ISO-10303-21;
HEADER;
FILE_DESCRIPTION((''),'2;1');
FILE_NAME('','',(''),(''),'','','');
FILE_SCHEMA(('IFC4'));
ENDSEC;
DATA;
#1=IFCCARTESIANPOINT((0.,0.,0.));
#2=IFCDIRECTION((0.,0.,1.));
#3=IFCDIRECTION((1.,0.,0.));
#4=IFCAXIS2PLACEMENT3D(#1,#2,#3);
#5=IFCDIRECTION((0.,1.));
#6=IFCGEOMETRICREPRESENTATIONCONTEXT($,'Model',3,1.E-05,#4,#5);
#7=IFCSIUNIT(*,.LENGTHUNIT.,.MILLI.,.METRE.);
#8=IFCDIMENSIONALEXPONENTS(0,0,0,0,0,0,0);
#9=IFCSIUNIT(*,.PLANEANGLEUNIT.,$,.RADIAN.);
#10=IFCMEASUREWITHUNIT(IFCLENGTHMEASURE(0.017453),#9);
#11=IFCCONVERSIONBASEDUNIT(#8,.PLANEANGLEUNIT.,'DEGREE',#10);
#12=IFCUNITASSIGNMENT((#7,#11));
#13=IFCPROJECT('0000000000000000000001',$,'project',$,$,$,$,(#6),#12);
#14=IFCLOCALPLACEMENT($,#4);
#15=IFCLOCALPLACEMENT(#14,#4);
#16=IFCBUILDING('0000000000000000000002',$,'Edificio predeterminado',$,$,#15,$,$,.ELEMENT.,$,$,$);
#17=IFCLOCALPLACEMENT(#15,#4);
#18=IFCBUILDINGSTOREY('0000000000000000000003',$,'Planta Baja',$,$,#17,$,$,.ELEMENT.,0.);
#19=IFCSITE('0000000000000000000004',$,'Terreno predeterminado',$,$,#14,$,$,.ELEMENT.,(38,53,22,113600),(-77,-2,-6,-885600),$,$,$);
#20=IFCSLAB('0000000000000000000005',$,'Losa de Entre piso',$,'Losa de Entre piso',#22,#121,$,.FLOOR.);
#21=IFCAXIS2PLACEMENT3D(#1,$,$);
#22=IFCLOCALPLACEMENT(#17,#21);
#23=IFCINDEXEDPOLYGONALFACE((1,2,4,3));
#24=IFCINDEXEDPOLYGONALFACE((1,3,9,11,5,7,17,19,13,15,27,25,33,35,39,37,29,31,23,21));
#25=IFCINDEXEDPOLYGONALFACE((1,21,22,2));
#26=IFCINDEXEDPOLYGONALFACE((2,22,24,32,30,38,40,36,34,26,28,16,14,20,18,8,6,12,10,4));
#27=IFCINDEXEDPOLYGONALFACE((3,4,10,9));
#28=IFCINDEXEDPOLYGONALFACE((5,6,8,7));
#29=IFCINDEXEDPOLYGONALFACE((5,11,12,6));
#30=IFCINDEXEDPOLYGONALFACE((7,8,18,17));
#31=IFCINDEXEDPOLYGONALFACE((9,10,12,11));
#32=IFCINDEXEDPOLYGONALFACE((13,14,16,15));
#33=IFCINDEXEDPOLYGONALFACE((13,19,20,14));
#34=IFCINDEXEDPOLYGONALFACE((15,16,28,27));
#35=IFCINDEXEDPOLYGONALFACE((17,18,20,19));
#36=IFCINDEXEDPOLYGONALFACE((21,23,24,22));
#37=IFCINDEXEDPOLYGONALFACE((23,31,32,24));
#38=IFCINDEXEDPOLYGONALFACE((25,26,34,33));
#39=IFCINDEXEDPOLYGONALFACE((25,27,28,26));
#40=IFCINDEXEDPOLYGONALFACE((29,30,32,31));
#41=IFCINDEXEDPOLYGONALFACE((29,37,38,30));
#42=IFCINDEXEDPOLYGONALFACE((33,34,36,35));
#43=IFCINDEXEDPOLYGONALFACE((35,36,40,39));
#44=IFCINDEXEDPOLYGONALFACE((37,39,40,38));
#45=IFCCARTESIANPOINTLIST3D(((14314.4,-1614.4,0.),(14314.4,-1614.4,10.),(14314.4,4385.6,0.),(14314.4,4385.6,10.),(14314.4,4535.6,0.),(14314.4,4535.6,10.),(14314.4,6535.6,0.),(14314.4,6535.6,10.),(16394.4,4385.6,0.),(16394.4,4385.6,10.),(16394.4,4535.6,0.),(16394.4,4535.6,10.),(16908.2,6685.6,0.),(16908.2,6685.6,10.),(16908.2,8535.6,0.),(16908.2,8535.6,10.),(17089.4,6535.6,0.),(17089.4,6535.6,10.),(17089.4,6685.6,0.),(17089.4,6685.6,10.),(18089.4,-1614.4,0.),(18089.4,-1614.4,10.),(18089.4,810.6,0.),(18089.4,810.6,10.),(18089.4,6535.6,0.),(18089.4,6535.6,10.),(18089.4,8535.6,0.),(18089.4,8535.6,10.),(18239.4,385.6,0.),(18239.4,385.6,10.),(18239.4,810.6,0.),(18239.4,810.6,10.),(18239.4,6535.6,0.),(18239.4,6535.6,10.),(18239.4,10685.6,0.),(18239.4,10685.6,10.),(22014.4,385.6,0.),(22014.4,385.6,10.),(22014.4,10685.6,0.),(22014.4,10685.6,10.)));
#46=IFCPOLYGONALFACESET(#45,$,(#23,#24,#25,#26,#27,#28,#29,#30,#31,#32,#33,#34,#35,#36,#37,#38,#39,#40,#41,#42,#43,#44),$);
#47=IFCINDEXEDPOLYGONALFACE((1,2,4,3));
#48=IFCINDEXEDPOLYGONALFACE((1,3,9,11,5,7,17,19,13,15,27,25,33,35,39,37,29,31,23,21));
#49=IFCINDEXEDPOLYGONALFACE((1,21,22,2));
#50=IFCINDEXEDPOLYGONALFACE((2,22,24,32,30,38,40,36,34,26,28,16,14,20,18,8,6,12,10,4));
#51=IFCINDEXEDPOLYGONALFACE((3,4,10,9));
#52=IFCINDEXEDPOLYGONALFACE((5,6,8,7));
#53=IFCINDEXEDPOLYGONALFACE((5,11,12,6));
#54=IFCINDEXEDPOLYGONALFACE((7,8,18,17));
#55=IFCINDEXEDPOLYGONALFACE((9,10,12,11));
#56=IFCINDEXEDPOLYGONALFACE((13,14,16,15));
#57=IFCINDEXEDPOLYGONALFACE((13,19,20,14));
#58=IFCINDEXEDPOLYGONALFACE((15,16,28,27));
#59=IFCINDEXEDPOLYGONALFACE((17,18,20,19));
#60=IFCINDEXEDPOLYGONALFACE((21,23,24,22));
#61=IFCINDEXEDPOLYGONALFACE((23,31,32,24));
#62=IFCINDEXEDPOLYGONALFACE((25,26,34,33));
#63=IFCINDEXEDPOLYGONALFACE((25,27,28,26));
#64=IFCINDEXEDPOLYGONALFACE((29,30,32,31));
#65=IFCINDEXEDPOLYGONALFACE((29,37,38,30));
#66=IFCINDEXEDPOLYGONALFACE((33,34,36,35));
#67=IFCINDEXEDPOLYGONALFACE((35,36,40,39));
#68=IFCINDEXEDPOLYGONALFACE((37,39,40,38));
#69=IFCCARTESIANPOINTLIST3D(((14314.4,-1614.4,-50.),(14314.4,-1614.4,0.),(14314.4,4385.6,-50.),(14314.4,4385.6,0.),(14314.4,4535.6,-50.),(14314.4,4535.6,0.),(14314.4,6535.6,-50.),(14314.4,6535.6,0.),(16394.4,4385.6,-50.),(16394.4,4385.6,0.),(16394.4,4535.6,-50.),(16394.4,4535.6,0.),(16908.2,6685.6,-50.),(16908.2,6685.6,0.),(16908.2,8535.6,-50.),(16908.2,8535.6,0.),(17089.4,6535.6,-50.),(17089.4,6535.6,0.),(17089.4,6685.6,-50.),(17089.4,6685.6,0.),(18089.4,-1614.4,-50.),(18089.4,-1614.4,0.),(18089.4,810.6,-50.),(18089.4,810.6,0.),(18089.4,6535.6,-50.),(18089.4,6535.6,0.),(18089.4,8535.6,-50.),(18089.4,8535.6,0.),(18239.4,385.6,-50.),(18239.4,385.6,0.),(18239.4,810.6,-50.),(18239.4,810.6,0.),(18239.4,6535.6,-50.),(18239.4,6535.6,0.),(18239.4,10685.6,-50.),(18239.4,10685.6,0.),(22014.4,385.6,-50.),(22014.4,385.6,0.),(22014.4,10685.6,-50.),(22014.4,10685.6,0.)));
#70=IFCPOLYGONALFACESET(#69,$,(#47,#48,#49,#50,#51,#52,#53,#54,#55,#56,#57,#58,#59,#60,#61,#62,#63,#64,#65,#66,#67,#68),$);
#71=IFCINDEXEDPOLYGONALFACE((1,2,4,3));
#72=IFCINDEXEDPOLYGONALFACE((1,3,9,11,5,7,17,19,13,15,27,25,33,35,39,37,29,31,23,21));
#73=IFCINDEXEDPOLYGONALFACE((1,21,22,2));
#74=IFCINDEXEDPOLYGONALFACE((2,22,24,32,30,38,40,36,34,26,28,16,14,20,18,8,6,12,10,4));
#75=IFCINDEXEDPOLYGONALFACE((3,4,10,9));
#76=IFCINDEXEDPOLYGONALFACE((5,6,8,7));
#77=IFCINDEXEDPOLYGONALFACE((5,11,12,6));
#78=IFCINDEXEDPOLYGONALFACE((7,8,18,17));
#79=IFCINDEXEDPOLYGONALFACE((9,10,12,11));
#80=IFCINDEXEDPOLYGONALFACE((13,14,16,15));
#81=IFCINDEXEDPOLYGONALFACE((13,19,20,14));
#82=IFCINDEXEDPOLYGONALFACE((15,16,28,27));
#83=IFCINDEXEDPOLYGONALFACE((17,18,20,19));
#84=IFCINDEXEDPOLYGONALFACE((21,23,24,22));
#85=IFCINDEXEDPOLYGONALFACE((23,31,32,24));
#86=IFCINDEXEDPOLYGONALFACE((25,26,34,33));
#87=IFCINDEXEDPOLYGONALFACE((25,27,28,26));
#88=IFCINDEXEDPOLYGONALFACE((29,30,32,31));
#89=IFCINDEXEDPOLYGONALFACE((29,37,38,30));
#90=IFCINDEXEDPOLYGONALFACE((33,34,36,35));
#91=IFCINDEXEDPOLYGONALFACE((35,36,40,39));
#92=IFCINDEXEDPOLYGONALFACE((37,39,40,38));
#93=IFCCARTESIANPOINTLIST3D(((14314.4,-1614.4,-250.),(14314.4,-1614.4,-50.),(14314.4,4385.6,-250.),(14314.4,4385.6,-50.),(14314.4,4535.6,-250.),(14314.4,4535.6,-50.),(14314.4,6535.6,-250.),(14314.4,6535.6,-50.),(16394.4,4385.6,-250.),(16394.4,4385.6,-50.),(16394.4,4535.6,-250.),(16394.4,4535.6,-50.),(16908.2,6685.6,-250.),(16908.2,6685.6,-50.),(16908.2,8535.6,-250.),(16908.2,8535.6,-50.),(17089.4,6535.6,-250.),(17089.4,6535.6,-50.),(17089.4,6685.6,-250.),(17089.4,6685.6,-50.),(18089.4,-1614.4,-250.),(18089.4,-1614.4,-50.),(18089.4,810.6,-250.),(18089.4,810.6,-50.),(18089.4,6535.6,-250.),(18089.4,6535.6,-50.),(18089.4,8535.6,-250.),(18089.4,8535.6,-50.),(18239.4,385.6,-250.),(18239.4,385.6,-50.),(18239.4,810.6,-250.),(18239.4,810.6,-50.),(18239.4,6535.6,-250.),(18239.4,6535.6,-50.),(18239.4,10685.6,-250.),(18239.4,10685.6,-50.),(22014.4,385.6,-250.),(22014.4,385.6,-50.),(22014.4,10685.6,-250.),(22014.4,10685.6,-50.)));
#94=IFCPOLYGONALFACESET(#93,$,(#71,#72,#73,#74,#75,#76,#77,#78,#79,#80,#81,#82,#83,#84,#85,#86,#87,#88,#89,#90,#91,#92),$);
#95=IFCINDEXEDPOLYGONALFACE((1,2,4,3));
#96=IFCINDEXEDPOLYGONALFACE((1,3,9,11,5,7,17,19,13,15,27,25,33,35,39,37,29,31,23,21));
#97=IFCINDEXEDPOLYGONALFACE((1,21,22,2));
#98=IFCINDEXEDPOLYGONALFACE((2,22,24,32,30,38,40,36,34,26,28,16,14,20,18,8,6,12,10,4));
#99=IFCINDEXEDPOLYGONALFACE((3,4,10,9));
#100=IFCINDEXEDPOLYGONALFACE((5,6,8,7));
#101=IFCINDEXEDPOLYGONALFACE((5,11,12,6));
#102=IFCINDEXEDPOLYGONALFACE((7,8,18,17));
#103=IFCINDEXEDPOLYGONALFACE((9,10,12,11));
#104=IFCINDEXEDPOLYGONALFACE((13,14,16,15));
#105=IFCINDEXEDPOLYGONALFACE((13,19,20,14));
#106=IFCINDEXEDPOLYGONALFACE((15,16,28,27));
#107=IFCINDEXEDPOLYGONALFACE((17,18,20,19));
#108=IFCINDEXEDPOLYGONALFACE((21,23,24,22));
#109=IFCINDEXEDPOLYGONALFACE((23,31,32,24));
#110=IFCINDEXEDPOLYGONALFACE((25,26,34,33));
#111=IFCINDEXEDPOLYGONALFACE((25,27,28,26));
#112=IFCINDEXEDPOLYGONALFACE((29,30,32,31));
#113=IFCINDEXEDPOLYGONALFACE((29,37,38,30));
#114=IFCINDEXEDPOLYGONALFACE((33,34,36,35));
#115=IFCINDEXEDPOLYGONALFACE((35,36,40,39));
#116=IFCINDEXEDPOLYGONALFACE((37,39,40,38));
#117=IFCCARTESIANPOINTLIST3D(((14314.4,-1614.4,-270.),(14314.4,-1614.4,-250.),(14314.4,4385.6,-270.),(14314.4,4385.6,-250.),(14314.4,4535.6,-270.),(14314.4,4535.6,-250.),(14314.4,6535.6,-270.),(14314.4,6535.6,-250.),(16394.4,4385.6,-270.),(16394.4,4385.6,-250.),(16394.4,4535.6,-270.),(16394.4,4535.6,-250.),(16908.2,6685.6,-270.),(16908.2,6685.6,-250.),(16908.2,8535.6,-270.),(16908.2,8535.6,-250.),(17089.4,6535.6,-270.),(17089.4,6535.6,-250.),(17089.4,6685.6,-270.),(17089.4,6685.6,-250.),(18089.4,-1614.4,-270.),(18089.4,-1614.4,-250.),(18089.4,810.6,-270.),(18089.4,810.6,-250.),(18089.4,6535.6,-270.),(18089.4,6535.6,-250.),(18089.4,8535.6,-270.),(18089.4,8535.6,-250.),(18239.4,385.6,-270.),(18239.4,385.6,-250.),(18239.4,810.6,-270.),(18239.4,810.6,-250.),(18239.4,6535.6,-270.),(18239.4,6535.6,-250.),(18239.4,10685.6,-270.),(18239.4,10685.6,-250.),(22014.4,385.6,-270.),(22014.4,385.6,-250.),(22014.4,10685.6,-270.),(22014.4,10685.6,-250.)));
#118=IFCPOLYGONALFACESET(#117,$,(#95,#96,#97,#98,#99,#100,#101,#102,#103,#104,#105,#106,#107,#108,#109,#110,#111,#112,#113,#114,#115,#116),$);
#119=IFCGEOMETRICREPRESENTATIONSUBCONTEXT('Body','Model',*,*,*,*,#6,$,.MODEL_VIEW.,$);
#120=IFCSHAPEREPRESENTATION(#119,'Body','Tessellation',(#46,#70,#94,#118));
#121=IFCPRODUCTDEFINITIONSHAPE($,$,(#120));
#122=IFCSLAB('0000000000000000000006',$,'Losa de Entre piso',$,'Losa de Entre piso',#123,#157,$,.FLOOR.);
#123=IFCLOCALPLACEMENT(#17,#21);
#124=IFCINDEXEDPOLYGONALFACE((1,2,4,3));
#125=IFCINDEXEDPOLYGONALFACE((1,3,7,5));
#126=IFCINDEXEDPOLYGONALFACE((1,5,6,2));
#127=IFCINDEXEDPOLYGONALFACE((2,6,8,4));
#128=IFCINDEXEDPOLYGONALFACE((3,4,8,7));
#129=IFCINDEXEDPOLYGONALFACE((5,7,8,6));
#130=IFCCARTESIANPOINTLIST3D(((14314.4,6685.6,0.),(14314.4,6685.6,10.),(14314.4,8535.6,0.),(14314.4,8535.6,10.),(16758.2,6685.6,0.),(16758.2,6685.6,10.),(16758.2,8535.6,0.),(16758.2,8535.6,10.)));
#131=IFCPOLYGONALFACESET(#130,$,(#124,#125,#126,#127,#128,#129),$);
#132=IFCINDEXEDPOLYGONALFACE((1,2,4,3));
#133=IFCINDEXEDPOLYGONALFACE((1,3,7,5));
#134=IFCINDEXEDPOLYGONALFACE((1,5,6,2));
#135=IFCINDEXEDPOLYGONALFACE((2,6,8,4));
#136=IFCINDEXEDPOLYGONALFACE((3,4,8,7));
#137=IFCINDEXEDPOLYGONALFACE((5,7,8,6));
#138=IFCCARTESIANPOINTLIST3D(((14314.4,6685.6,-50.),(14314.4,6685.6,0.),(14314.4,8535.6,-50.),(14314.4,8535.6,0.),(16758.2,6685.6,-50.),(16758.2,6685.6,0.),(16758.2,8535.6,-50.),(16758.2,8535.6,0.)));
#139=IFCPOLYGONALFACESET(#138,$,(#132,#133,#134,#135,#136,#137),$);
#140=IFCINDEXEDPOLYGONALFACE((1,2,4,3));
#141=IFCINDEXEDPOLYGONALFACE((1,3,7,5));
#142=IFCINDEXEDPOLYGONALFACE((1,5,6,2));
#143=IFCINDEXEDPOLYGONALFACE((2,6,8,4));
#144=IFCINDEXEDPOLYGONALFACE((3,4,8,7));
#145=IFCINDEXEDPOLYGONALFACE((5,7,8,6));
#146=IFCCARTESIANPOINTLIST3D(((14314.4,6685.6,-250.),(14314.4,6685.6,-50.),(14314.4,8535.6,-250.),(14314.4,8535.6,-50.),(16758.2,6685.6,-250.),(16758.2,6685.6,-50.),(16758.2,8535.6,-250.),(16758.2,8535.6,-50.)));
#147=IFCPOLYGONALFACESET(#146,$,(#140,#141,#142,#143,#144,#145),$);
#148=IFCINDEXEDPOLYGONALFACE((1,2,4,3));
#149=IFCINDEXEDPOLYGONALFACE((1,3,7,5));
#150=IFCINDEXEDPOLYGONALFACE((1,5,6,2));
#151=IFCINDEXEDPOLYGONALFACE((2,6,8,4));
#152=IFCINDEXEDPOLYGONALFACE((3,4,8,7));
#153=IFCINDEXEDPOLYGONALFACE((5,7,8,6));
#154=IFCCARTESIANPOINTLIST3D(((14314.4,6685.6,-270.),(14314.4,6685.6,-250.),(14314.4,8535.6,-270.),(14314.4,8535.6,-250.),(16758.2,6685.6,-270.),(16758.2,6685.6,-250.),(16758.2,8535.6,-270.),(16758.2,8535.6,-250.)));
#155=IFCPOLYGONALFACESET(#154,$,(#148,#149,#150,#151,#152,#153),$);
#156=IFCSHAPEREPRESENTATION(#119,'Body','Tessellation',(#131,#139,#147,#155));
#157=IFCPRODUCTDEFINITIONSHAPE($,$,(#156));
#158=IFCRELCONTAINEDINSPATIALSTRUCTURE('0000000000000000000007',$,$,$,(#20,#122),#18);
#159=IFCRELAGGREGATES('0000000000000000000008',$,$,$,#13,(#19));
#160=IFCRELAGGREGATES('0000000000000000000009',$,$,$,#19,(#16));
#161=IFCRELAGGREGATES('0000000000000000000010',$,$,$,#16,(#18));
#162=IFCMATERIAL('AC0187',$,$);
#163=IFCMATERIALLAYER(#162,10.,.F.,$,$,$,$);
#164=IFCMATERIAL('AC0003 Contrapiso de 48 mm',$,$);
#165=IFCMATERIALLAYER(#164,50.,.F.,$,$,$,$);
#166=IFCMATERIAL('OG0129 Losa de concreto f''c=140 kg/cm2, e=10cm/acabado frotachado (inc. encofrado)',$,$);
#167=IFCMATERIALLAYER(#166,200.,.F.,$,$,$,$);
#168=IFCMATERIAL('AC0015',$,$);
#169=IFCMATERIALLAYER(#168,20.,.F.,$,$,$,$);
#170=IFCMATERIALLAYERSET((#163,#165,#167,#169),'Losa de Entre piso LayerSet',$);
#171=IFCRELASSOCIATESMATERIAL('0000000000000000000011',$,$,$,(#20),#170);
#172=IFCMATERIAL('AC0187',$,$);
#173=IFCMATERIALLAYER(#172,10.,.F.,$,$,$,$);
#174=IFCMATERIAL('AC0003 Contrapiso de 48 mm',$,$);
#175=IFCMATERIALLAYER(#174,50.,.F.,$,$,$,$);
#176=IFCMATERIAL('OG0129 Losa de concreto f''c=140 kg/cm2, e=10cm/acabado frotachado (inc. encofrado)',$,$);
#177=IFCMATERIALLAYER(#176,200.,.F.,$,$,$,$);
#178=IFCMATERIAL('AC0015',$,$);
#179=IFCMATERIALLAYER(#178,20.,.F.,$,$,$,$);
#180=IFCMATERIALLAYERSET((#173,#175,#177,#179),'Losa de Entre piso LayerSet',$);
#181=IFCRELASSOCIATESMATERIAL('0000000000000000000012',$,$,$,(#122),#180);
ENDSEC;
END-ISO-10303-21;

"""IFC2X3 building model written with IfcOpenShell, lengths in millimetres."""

from ifc_helpers import new_model, entity, si_unit, converted_unit, direction, frame, origin_with_axes, place, context, subcontext, project, spatial, polyline, outline, extrude, material, layer, layer_set, layer_usage, element, save


model = new_model("IFC2X3")

# Units and contexts
model_context = context("Model", 3, precision=1e-05, world=origin_with_axes(), true_north=direction((0.0, 1.0)))
body_context = subcontext(model_context, "Body", "Model", "MODEL_VIEW")
ifc_project = project(units=[si_unit("LENGTHUNIT", "METRE", prefix="MILLI"), converted_unit("PLANEANGLEUNIT", "DEGREE", entity("IfcLengthMeasure", 0.017453), si_unit("PLANEANGLEUNIT", "RADIAN"), dimensions=[0, 0, 0, 0, 0, 0, 0])], contexts=[model_context])

# Site, building, storey
site_placement = place(None, origin_with_axes())
site = spatial("IfcSite", under=ifc_project, at=site_placement, Name="Terreno predeterminado", CompositionType="ELEMENT", RefLatitude=(38, 53, 22, 113600), RefLongitude=(-77, -2, -6, -885600))
building_placement = place(site_placement, origin_with_axes())
building = spatial("IfcBuilding", under=site, at=building_placement, Name="Edificio predeterminado", CompositionType="ELEMENT")
storey_placement = place(building_placement, origin_with_axes())
storey = spatial("IfcBuildingStorey", under=building, at=storey_placement, Name="Planta Baja", CompositionType="ELEMENT", Elevation=0.0)

# Slabs
ifc_material_1 = material(Name="AC0187")
ifc_layer_1 = layer(ifc_material_1, 10.0, ventilated=False)
ifc_material_2 = material(Name="AC0003 Contrapiso de 48 mm")
ifc_layer_2 = layer(ifc_material_2, 50.0, ventilated=False)
ifc_material_3 = material(Name="OG0129 Losa de concreto f'c=140 kg/cm2, e=10cm/acabado frotachado (inc. encofrado)")
ifc_layer_3 = layer(ifc_material_3, 200.0, ventilated=False)
ifc_material_4 = material(Name="AC0015")
ifc_layer_4 = layer(ifc_material_4, 20.0, ventilated=False)
ifc_layer_set_1 = layer_set([ifc_layer_1, ifc_layer_2, ifc_layer_3, ifc_layer_4], Name="Losa de Entre piso LayerSet")
ifc_layer_usage_1 = layer_usage(ifc_layer_set_1, "AXIS3", "POSITIVE", 0.0)
slab_1_placement = place(storey_placement, origin_with_axes())
element("IfcSlab", 1, at=slab_1_placement, inside=storey, material=ifc_layer_usage_1, Name="Losa de Entre piso", ObjectType="Losa de Entre piso", PredefinedType="FLOOR", context=body_context, shape_type="SweptSolid", body=[
    extrude(outline(polyline([(0.0, -6000.0), (3775.0, -6000.0), (3775.0, -3575.0), (3925.0, -3575.0), (3925.0, -4000.0), (7700.0, -4000.0), (7700.0, 6300.0), (3925.0, 6300.0), (3925.0, 2150.0), (3775.0, 2150.0), (3775.0, 4150.0), (2593.9, 4150.0), (2593.9, 2300.0), (2775.0, 2300.0), (2775.0, 2150.0), (0.0, 2150.0), (0.0, 150.0), (2080.0, 150.0), (2080.0, 0.0), (0.0, 0.0), (0.0, -6000.0)])), frame((14314.4, 4385.6, 0.0), z_axis=(0.0, 0.0, 1.0), x_axis=(1.0, 0.0, 0.0)), (0.0, 0.0, 1.0), 10.0),
    extrude(outline(polyline([(0.0, -6000.0), (3775.0, -6000.0), (3775.0, -3575.0), (3925.0, -3575.0), (3925.0, -4000.0), (7700.0, -4000.0), (7700.0, 6300.0), (3925.0, 6300.0), (3925.0, 2150.0), (3775.0, 2150.0), (3775.0, 4150.0), (2593.9, 4150.0), (2593.9, 2300.0), (2775.0, 2300.0), (2775.0, 2150.0), (0.0, 2150.0), (0.0, 150.0), (2080.0, 150.0), (2080.0, 0.0), (0.0, 0.0), (0.0, -6000.0)])), frame((14314.4, 4385.6, -50.0), z_axis=(0.0, 0.0, 1.0), x_axis=(1.0, 0.0, 0.0)), (0.0, 0.0, 1.0), 50.0),
    extrude(outline(polyline([(0.0, -6000.0), (3775.0, -6000.0), (3775.0, -3575.0), (3925.0, -3575.0), (3925.0, -4000.0), (7700.0, -4000.0), (7700.0, 6300.0), (3925.0, 6300.0), (3925.0, 2150.0), (3775.0, 2150.0), (3775.0, 4150.0), (2593.9, 4150.0), (2593.9, 2300.0), (2775.0, 2300.0), (2775.0, 2150.0), (0.0, 2150.0), (0.0, 150.0), (2080.0, 150.0), (2080.0, 0.0), (0.0, 0.0), (0.0, -6000.0)])), frame((14314.4, 4385.6, -250.0), z_axis=(0.0, 0.0, 1.0), x_axis=(1.0, 0.0, 0.0)), (0.0, 0.0, 1.0), 200.0),
    extrude(outline(polyline([(0.0, -6000.0), (3775.0, -6000.0), (3775.0, -3575.0), (3925.0, -3575.0), (3925.0, -4000.0), (7700.0, -4000.0), (7700.0, 6300.0), (3925.0, 6300.0), (3925.0, 2150.0), (3775.0, 2150.0), (3775.0, 4150.0), (2593.9, 4150.0), (2593.9, 2300.0), (2775.0, 2300.0), (2775.0, 2150.0), (0.0, 2150.0), (0.0, 150.0), (2080.0, 150.0), (2080.0, 0.0), (0.0, 0.0), (0.0, -6000.0)])), frame((14314.4, 4385.6, -270.0), z_axis=(0.0, 0.0, 1.0), x_axis=(1.0, 0.0, 0.0)), (0.0, 0.0, 1.0), 20.0),
])
ifc_material_5 = material(Name="AC0187")
ifc_layer_5 = layer(ifc_material_5, 10.0, ventilated=False)
ifc_material_6 = material(Name="AC0003 Contrapiso de 48 mm")
ifc_layer_6 = layer(ifc_material_6, 50.0, ventilated=False)
ifc_material_7 = material(Name="OG0129 Losa de concreto f'c=140 kg/cm2, e=10cm/acabado frotachado (inc. encofrado)")
ifc_layer_7 = layer(ifc_material_7, 200.0, ventilated=False)
ifc_material_8 = material(Name="AC0015")
ifc_layer_8 = layer(ifc_material_8, 20.0, ventilated=False)
ifc_layer_set_2 = layer_set([ifc_layer_5, ifc_layer_6, ifc_layer_7, ifc_layer_8], Name="Losa de Entre piso LayerSet")
ifc_layer_usage_2 = layer_usage(ifc_layer_set_2, "AXIS3", "NEGATIVE", 0.0)
slab_2_placement = place(storey_placement, origin_with_axes())
element("IfcSlab", 2, at=slab_2_placement, inside=storey, material=ifc_layer_usage_2, Name="Losa de Entre piso", ObjectType="Losa de Entre piso", PredefinedType="FLOOR", context=body_context, shape_type="SweptSolid", body=[
    extrude(outline(polyline([(0.0, 2443.9), (1850.0, 2443.9), (1850.0, 0.0), (0.0, 0.0), (0.0, 2443.9)])), frame((14314.4, 6685.6, 0.0), z_axis=(0.0, 0.0, -1.0), x_axis=(0.0, 1.0, 0.0)), (0.0, 0.0, -1.0), 10.0),
    extrude(outline(polyline([(0.0, 2443.9), (1850.0, 2443.9), (1850.0, 0.0), (0.0, 0.0), (0.0, 2443.9)])), frame((14314.4, 6685.6, -50.0), z_axis=(0.0, 0.0, -1.0), x_axis=(0.0, 1.0, 0.0)), (0.0, 0.0, -1.0), 50.0),
    extrude(outline(polyline([(0.0, 2443.9), (1850.0, 2443.9), (1850.0, 0.0), (0.0, 0.0), (0.0, 2443.9)])), frame((14314.4, 6685.6, -250.0), z_axis=(0.0, 0.0, -1.0), x_axis=(0.0, 1.0, 0.0)), (0.0, 0.0, -1.0), 200.0),
    extrude(outline(polyline([(0.0, 2443.9), (1850.0, 2443.9), (1850.0, 0.0), (0.0, 0.0), (0.0, 2443.9)])), frame((14314.4, 6685.6, -270.0), z_axis=(0.0, 0.0, -1.0), x_axis=(0.0, 1.0, 0.0)), (0.0, 0.0, -1.0), 20.0),
])

save(model, "model.ifc")
